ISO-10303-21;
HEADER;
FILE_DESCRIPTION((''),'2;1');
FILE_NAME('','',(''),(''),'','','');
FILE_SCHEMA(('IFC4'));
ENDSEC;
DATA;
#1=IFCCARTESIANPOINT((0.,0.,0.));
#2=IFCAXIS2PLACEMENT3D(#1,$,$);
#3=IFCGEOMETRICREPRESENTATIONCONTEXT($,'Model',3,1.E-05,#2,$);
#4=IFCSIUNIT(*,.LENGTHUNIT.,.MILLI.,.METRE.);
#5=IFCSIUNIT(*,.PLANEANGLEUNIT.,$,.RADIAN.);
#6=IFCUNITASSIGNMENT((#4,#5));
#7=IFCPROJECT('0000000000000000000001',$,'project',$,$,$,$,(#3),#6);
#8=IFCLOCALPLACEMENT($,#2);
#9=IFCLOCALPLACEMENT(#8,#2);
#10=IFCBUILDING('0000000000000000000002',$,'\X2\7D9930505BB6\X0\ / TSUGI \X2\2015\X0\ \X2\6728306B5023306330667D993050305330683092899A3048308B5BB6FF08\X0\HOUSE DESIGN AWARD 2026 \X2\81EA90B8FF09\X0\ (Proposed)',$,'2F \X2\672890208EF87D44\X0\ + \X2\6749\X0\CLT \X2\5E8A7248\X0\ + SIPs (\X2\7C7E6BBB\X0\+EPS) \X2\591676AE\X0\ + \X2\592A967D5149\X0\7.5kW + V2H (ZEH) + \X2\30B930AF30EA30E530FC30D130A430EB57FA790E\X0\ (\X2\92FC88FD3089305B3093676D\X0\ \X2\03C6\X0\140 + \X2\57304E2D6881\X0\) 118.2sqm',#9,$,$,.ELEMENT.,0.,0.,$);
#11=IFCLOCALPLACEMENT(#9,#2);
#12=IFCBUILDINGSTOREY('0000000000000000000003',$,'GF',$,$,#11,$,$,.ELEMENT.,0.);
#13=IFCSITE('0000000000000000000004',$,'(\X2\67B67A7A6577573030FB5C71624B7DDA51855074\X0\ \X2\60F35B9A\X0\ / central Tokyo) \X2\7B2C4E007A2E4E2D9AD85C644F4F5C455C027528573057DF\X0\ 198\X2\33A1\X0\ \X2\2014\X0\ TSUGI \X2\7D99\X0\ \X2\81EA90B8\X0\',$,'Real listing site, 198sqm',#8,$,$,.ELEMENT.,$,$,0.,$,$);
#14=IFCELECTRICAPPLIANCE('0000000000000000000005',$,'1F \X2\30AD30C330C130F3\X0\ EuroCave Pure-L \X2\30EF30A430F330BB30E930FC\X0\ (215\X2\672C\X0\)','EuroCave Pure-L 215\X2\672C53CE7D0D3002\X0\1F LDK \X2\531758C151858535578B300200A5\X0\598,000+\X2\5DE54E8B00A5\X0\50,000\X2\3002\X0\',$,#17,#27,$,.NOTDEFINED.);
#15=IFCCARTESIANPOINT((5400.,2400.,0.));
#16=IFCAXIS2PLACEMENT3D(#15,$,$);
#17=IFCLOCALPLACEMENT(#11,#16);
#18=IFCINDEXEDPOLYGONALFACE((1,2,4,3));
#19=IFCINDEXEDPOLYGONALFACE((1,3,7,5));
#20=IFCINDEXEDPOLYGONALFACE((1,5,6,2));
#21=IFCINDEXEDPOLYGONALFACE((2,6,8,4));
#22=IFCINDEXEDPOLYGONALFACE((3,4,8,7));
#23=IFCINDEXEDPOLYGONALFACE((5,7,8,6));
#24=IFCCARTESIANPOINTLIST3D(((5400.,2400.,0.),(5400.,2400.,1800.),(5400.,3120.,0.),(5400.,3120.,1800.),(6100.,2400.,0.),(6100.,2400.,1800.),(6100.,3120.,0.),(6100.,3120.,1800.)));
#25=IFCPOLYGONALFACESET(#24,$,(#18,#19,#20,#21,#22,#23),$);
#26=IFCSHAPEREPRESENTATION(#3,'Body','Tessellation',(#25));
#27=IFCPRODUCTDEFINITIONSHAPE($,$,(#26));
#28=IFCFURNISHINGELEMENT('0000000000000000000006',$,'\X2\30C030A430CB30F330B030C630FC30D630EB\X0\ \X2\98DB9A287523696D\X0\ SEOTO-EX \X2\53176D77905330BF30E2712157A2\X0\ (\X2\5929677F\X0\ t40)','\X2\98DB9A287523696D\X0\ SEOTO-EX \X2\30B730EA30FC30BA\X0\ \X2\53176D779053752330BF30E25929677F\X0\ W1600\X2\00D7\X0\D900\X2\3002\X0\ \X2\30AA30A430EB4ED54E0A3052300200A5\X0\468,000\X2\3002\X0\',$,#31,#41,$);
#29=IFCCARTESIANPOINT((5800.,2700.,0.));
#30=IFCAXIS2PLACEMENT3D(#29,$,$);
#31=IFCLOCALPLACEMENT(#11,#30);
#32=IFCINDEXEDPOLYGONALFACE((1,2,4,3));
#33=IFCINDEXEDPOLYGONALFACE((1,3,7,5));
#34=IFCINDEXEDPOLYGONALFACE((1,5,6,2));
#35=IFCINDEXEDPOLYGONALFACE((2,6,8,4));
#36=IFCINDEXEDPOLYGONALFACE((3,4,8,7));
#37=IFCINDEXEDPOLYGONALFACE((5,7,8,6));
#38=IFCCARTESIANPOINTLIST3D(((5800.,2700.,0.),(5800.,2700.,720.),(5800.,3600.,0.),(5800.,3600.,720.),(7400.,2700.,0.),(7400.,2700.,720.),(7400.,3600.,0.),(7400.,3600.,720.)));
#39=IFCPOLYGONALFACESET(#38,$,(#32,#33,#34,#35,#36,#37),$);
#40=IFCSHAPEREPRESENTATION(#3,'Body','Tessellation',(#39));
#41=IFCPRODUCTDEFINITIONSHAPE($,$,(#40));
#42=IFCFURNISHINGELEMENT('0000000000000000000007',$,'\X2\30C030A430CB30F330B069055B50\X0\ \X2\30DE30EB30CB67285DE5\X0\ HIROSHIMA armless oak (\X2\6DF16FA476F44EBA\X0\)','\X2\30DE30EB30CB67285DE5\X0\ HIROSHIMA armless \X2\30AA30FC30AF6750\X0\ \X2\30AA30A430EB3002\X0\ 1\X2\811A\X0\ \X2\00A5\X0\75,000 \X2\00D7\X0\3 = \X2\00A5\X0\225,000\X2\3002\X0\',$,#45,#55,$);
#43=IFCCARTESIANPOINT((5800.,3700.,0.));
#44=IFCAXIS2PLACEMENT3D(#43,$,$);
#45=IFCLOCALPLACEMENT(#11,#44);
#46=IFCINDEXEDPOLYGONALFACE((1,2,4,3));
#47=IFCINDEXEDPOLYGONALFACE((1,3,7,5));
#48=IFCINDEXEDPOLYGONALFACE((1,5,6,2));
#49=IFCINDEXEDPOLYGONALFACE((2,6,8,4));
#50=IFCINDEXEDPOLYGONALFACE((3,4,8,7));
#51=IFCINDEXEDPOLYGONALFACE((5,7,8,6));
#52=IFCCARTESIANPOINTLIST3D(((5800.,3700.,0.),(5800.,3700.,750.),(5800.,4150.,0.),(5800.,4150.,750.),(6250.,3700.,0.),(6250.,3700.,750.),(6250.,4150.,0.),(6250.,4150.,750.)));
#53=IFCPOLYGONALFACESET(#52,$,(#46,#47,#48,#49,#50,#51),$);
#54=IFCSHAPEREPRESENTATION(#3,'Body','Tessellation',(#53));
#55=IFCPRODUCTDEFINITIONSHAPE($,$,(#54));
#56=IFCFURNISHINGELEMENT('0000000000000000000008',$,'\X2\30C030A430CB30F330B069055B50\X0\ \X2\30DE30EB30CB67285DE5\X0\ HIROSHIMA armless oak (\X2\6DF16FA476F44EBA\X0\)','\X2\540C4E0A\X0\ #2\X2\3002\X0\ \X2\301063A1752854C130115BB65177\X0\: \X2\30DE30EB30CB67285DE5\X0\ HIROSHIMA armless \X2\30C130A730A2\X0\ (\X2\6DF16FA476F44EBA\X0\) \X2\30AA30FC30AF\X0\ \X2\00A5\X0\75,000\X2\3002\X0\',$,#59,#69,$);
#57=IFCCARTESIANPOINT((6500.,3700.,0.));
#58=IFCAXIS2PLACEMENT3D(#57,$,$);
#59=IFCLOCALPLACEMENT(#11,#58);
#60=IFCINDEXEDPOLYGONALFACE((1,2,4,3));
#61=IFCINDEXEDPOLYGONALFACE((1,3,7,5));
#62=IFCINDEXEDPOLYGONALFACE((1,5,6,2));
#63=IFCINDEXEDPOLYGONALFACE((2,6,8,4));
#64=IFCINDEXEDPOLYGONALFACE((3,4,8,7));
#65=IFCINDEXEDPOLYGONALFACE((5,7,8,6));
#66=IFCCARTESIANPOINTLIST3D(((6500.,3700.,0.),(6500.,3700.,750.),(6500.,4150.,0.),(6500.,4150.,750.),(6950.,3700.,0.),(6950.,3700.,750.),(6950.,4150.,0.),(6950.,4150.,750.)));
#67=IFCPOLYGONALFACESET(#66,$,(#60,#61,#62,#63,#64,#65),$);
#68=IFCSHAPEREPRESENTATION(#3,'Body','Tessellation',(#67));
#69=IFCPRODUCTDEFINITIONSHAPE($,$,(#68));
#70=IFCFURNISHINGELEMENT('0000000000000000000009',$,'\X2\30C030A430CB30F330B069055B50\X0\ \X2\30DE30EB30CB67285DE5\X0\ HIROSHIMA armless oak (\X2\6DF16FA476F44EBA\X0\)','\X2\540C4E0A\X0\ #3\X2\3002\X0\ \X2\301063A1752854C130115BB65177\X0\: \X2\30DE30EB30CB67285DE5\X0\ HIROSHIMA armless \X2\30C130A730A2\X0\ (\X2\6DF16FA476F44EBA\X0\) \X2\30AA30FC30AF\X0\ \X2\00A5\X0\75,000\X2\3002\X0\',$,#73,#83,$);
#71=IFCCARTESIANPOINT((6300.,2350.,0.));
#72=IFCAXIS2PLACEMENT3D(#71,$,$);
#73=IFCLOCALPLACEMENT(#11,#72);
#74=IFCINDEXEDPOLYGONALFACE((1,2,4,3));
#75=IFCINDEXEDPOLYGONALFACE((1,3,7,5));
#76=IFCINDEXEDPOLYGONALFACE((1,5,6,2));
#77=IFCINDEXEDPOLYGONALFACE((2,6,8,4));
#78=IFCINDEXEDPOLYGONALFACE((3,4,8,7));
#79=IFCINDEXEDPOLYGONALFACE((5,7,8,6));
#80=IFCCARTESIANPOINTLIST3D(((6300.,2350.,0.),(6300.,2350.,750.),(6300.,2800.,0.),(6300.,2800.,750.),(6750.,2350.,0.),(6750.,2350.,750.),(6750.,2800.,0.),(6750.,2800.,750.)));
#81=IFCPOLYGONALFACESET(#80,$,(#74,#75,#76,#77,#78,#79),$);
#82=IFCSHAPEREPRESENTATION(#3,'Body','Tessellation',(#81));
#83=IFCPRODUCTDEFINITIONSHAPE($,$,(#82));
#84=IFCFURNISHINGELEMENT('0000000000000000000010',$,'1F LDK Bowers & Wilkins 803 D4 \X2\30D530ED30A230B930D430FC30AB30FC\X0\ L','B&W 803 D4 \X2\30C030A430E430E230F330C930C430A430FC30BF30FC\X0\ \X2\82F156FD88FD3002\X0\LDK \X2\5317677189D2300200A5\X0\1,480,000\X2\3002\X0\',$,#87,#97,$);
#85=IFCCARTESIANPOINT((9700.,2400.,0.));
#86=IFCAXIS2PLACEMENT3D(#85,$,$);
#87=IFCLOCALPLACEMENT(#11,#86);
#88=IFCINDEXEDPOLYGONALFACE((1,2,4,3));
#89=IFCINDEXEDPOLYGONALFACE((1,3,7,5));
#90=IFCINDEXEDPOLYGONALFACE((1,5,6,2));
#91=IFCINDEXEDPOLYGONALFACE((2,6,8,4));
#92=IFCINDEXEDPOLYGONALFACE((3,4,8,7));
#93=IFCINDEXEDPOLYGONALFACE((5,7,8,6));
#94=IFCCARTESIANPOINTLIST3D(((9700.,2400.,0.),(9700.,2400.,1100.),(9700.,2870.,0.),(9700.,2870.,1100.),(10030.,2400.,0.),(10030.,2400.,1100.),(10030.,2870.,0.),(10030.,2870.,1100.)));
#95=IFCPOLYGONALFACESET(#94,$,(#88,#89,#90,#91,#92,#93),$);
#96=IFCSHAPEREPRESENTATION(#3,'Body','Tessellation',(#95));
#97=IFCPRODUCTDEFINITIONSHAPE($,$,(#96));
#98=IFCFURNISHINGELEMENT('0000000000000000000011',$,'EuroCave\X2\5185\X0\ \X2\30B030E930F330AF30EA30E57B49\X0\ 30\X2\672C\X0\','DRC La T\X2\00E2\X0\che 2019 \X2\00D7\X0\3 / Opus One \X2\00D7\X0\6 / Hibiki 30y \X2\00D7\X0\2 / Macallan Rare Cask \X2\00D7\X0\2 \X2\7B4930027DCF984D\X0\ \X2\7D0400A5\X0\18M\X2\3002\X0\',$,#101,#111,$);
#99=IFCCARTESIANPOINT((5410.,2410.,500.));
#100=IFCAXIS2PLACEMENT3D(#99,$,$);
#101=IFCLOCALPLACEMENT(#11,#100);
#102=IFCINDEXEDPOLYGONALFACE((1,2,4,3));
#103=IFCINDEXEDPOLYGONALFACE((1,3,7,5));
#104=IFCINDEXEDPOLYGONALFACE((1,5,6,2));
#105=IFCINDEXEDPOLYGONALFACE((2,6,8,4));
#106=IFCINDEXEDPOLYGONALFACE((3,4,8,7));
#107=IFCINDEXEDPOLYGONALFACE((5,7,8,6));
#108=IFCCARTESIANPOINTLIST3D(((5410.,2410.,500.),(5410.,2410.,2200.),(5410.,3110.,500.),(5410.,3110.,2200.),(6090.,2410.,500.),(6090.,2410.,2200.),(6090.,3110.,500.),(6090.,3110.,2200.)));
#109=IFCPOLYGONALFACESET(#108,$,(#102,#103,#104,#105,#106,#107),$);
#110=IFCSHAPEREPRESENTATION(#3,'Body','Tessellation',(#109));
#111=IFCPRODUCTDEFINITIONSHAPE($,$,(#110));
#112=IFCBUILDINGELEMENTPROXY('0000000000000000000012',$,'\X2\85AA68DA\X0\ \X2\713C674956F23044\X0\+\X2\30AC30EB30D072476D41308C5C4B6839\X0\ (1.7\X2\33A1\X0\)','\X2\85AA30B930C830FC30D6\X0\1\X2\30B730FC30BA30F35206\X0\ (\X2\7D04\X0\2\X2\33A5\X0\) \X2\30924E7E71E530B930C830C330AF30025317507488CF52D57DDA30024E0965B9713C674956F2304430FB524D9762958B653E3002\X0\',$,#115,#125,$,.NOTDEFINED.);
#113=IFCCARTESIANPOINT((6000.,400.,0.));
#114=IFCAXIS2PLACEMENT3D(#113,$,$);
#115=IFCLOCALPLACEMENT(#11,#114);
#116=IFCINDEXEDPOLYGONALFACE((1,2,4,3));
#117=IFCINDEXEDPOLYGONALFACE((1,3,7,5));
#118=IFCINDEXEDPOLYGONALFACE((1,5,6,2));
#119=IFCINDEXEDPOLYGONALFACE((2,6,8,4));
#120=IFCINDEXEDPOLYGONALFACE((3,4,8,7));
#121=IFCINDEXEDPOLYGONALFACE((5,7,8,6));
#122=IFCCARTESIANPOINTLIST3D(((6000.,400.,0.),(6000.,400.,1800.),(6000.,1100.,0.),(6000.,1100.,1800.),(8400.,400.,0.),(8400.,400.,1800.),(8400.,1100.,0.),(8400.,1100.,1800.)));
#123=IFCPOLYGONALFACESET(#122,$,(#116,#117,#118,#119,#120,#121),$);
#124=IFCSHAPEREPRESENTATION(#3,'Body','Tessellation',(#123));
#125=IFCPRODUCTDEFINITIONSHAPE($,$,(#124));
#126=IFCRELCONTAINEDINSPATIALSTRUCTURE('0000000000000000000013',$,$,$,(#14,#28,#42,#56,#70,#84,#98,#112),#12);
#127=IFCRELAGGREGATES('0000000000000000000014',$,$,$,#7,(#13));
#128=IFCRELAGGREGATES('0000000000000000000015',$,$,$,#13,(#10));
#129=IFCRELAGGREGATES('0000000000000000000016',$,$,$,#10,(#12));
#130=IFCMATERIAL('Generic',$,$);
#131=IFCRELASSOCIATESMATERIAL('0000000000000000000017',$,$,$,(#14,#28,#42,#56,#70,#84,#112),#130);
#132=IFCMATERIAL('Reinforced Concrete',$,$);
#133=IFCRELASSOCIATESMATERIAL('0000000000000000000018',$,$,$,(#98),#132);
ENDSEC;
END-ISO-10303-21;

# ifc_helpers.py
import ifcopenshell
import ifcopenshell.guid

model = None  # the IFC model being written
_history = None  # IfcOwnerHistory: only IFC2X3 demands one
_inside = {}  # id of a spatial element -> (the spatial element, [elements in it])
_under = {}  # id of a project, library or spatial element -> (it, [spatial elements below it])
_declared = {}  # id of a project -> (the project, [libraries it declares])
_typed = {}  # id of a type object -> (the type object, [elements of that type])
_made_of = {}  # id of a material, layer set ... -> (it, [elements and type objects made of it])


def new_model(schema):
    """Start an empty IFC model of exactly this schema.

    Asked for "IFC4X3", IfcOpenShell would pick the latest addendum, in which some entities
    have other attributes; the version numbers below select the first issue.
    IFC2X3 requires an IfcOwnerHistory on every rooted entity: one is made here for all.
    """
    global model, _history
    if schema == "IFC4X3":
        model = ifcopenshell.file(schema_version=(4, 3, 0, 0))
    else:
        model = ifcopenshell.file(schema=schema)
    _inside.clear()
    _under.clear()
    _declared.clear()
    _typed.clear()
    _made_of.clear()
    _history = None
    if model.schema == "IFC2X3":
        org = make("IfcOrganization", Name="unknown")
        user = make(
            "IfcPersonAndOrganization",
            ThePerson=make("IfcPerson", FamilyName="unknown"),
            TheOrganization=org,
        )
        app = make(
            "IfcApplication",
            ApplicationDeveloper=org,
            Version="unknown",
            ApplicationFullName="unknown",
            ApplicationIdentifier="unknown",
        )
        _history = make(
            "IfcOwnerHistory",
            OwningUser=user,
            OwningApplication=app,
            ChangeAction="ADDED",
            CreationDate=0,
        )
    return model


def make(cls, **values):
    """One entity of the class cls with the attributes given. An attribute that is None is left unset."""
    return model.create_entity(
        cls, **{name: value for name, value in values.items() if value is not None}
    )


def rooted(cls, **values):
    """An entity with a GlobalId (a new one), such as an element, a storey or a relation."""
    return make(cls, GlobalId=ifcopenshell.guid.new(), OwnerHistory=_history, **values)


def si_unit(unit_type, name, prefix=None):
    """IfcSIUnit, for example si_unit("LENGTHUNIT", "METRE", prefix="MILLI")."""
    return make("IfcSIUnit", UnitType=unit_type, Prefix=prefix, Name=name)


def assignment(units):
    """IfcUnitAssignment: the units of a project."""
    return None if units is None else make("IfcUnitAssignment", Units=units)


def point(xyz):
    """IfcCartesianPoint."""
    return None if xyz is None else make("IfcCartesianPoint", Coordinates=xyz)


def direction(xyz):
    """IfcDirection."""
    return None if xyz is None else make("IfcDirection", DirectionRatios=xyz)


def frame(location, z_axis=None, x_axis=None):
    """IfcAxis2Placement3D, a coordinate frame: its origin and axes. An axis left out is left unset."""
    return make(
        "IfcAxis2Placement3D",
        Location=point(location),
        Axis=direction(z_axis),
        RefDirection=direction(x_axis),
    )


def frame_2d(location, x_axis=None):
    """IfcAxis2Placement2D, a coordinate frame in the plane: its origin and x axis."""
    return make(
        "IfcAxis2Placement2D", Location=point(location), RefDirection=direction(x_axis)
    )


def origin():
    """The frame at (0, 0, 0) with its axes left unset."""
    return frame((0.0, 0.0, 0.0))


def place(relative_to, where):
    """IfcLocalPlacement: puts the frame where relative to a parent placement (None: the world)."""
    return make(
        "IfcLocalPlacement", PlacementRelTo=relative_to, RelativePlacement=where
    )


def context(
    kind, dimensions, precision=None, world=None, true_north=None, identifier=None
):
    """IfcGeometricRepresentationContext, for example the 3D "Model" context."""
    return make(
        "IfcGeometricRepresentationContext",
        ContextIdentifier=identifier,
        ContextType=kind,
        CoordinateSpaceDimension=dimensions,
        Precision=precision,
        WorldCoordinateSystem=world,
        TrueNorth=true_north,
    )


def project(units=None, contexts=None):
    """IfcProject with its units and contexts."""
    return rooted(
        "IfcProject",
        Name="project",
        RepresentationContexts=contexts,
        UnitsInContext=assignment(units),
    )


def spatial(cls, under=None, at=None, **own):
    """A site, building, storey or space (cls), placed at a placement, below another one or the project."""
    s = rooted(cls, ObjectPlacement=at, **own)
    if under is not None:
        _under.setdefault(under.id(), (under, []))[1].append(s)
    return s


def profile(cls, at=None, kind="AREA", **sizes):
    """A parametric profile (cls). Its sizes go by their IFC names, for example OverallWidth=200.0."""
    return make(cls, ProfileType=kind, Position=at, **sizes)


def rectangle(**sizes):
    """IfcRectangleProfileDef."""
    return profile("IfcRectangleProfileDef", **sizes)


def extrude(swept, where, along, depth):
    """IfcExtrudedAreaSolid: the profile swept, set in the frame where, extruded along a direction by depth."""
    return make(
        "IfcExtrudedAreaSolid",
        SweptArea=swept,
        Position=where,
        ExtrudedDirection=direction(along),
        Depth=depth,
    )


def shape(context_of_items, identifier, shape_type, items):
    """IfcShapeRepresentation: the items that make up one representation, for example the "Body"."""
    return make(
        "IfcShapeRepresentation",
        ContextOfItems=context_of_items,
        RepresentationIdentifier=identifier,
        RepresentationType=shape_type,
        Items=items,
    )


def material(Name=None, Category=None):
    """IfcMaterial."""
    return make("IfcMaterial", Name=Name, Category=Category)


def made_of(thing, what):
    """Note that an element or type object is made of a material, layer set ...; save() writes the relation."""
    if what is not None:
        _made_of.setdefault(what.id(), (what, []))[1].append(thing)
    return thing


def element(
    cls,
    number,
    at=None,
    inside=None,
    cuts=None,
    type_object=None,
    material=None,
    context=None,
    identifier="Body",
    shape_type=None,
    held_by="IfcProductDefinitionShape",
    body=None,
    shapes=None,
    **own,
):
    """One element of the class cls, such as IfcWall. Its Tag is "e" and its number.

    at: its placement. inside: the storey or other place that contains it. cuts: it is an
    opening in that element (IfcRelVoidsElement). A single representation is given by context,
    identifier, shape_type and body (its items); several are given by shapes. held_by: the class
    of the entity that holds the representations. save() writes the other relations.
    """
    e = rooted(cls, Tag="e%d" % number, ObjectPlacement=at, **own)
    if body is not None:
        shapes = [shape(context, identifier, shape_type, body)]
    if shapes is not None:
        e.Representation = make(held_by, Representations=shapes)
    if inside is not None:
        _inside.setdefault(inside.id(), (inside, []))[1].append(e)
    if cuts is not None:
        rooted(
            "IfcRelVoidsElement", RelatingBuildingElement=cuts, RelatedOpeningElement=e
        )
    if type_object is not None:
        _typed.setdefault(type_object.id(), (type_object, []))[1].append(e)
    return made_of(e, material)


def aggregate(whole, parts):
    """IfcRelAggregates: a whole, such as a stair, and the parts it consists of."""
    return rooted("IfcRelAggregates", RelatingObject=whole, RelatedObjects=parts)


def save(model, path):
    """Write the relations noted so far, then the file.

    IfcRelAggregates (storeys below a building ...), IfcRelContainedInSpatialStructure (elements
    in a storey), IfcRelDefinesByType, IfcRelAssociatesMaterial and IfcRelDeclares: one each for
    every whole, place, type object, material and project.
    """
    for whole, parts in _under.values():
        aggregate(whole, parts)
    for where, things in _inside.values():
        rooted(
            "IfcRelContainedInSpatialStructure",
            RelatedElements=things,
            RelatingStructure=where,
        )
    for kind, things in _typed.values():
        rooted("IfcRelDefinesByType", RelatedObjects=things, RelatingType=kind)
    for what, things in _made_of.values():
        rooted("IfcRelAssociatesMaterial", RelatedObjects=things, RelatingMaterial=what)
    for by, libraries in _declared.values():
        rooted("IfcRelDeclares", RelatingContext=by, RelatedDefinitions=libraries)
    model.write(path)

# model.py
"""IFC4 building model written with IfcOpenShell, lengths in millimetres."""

from ifc_helpers import new_model, si_unit, frame, frame_2d, origin, place, context, project, spatial, rectangle, extrude, material, element, save


model = new_model("IFC4")

# Units and contexts
model_context = context("Model", 3, precision=1e-05, world=origin())
ifc_project = project(units=[si_unit("LENGTHUNIT", "METRE", prefix="MILLI"), si_unit("PLANEANGLEUNIT", "RADIAN")], contexts=[model_context])

# Site, building, storey
site_placement = place(None, origin())
site = spatial("IfcSite", under=ifc_project, at=site_placement, Name="(架空敷地・山手線内側 想定 / central Tokyo) 第一種中高層住居専用地域 198㎡ — TSUGI 継 自邸", ObjectType="Real listing site, 198sqm", CompositionType="ELEMENT", RefElevation=0.0)
building_placement = place(site_placement, origin())
building = spatial("IfcBuilding", under=site, at=building_placement, Name="継ぐ家 / TSUGI ― 木に倣って継ぐことを覚える家（HOUSE DESIGN AWARD 2026 自邸） (Proposed)", ObjectType="2F 木造軸組 + 杉CLT 床版 + SIPs (籾殻+EPS) 外皮 + 太陽光7.5kW + V2H (ZEH) + スクリューパイル基礎 (鋼製らせん杭 φ140 + 地中梁) 118.2sqm", CompositionType="ELEMENT", ElevationOfRefHeight=0.0, ElevationOfTerrain=0.0)
storey_placement = place(building_placement, origin())
storey = spatial("IfcBuildingStorey", under=building, at=storey_placement, Name="GF", CompositionType="ELEMENT", Elevation=0.0)

# Shared definitions
ifc_material_1 = material(Name="Generic")

# Electric appliance
electric_appliance_1_placement = place(storey_placement, frame((5400.0, 2400.0, 0.0)))
element("IfcElectricAppliance", 1, at=electric_appliance_1_placement, inside=storey, material=ifc_material_1, Name="1F キッチン EuroCave Pure-L ワインセラー (215本)", Description="EuroCave Pure-L 215本収納。1F LDK 北壁内蔵型。¥598,000+工事¥50,000。", PredefinedType="NOTDEFINED", context=model_context, shape_type="SweptSolid", body=[
    extrude(rectangle(XDim=700.0, YDim=720.0, at=frame_2d((350.0, 360.0))), frame((5400.0, 2400.0, 0.0)), (0.0, 0.0, 1.0), 1800.0),
])

# Furnishing elements
furnishing_1_placement = place(storey_placement, frame((5800.0, 2700.0, 0.0)))
element("IfcFurnishingElement", 2, at=furnishing_1_placement, inside=storey, material=ifc_material_1, Name="ダイニングテーブル 飛騨産業 SEOTO-EX 北海道タモ無垢 (天板 t40)", Description="飛騨産業 SEOTO-EX シリーズ 北海道産タモ天板 W1600×D900。 オイル仕上げ。¥468,000。", context=model_context, shape_type="SweptSolid", body=[
    extrude(rectangle(XDim=1600.0, YDim=900.0, at=frame_2d((800.0, 450.0))), frame((5800.0, 2700.0, 0.0)), (0.0, 0.0, 1.0), 720.0),
])
furnishing_2_placement = place(storey_placement, frame((5800.0, 3700.0, 0.0)))
element("IfcFurnishingElement", 3, at=furnishing_2_placement, inside=storey, material=ifc_material_1, Name="ダイニング椅子 マルニ木工 HIROSHIMA armless oak (深澤直人)", Description="マルニ木工 HIROSHIMA armless オーク材 オイル。 1脚 ¥75,000 ×3 = ¥225,000。", context=model_context, shape_type="SweptSolid", body=[
    extrude(rectangle(XDim=450.0, YDim=450.0, at=frame_2d((225.0, 225.0))), frame((5800.0, 3700.0, 0.0)), (0.0, 0.0, 1.0), 750.0),
])
furnishing_3_placement = place(storey_placement, frame((6500.0, 3700.0, 0.0)))
element("IfcFurnishingElement", 4, at=furnishing_3_placement, inside=storey, material=ifc_material_1, Name="ダイニング椅子 マルニ木工 HIROSHIMA armless oak (深澤直人)", Description="同上 #2。 【採用品】家具: マルニ木工 HIROSHIMA armless チェア (深澤直人) オーク ¥75,000。", context=model_context, shape_type="SweptSolid", body=[
    extrude(rectangle(XDim=450.0, YDim=450.0, at=frame_2d((225.0, 225.0))), frame((6500.0, 3700.0, 0.0)), (0.0, 0.0, 1.0), 750.0),
])
furnishing_4_placement = place(storey_placement, frame((6300.0, 2350.0, 0.0)))
element("IfcFurnishingElement", 5, at=furnishing_4_placement, inside=storey, material=ifc_material_1, Name="ダイニング椅子 マルニ木工 HIROSHIMA armless oak (深澤直人)", Description="同上 #3。 【採用品】家具: マルニ木工 HIROSHIMA armless チェア (深澤直人) オーク ¥75,000。", context=model_context, shape_type="SweptSolid", body=[
    extrude(rectangle(XDim=450.0, YDim=450.0, at=frame_2d((225.0, 225.0))), frame((6300.0, 2350.0, 0.0)), (0.0, 0.0, 1.0), 750.0),
])
furnishing_5_placement = place(storey_placement, frame((9700.0, 2400.0, 0.0)))
element("IfcFurnishingElement", 6, at=furnishing_5_placement, inside=storey, material=ifc_material_1, Name="1F LDK Bowers & Wilkins 803 D4 フロアスピーカー L", Description="B&W 803 D4 ダイヤモンドツイーター 英国製。LDK 北東角。¥1,480,000。", context=model_context, shape_type="SweptSolid", body=[
    extrude(rectangle(XDim=330.0, YDim=470.0, at=frame_2d((165.0, 235.0))), frame((9700.0, 2400.0, 0.0)), (0.0, 0.0, 1.0), 1100.0),
])
ifc_material_2 = material(Name="Reinforced Concrete")
furnishing_6_placement = place(storey_placement, frame((5410.0, 2410.0, 500.0)))
element("IfcFurnishingElement", 7, at=furnishing_6_placement, inside=storey, material=ifc_material_2, Name="EuroCave内 グランクリュ等 30本", Description="DRC La Tâche 2019 ×3 / Opus One ×6 / Hibiki 30y ×2 / Macallan Rare Cask ×2 等。総額 約¥18M。", context=model_context, shape_type="SweptSolid", body=[
    extrude(rectangle(XDim=680.0, YDim=700.0, at=frame_2d((340.0, 350.0))), frame((5410.0, 2410.0, 500.0)), (0.0, 0.0, 1.0), 1700.0),
])

# Building element proxy
proxy_placement = place(storey_placement, frame((6000.0, 400.0, 0.0)))
element("IfcBuildingElementProxy", 8, at=proxy_placement, inside=storey, material=ifc_material_1, Name="薪棚 焼杉囲い+ガルバ片流れ屋根 (1.7㎡)", Description="薪ストーブ1シーズン分 (約2㎥) を乾燥ストック。北側裏動線。三方焼杉囲い・前面開放。", PredefinedType="NOTDEFINED", context=model_context, shape_type="SweptSolid", body=[
    extrude(rectangle(XDim=2400.0, YDim=700.0, at=frame_2d((1200.0, 350.0))), frame((6000.0, 400.0, 0.0)), (0.0, 0.0, 1.0), 1800.0),
])

save(model, "model.ifc")
